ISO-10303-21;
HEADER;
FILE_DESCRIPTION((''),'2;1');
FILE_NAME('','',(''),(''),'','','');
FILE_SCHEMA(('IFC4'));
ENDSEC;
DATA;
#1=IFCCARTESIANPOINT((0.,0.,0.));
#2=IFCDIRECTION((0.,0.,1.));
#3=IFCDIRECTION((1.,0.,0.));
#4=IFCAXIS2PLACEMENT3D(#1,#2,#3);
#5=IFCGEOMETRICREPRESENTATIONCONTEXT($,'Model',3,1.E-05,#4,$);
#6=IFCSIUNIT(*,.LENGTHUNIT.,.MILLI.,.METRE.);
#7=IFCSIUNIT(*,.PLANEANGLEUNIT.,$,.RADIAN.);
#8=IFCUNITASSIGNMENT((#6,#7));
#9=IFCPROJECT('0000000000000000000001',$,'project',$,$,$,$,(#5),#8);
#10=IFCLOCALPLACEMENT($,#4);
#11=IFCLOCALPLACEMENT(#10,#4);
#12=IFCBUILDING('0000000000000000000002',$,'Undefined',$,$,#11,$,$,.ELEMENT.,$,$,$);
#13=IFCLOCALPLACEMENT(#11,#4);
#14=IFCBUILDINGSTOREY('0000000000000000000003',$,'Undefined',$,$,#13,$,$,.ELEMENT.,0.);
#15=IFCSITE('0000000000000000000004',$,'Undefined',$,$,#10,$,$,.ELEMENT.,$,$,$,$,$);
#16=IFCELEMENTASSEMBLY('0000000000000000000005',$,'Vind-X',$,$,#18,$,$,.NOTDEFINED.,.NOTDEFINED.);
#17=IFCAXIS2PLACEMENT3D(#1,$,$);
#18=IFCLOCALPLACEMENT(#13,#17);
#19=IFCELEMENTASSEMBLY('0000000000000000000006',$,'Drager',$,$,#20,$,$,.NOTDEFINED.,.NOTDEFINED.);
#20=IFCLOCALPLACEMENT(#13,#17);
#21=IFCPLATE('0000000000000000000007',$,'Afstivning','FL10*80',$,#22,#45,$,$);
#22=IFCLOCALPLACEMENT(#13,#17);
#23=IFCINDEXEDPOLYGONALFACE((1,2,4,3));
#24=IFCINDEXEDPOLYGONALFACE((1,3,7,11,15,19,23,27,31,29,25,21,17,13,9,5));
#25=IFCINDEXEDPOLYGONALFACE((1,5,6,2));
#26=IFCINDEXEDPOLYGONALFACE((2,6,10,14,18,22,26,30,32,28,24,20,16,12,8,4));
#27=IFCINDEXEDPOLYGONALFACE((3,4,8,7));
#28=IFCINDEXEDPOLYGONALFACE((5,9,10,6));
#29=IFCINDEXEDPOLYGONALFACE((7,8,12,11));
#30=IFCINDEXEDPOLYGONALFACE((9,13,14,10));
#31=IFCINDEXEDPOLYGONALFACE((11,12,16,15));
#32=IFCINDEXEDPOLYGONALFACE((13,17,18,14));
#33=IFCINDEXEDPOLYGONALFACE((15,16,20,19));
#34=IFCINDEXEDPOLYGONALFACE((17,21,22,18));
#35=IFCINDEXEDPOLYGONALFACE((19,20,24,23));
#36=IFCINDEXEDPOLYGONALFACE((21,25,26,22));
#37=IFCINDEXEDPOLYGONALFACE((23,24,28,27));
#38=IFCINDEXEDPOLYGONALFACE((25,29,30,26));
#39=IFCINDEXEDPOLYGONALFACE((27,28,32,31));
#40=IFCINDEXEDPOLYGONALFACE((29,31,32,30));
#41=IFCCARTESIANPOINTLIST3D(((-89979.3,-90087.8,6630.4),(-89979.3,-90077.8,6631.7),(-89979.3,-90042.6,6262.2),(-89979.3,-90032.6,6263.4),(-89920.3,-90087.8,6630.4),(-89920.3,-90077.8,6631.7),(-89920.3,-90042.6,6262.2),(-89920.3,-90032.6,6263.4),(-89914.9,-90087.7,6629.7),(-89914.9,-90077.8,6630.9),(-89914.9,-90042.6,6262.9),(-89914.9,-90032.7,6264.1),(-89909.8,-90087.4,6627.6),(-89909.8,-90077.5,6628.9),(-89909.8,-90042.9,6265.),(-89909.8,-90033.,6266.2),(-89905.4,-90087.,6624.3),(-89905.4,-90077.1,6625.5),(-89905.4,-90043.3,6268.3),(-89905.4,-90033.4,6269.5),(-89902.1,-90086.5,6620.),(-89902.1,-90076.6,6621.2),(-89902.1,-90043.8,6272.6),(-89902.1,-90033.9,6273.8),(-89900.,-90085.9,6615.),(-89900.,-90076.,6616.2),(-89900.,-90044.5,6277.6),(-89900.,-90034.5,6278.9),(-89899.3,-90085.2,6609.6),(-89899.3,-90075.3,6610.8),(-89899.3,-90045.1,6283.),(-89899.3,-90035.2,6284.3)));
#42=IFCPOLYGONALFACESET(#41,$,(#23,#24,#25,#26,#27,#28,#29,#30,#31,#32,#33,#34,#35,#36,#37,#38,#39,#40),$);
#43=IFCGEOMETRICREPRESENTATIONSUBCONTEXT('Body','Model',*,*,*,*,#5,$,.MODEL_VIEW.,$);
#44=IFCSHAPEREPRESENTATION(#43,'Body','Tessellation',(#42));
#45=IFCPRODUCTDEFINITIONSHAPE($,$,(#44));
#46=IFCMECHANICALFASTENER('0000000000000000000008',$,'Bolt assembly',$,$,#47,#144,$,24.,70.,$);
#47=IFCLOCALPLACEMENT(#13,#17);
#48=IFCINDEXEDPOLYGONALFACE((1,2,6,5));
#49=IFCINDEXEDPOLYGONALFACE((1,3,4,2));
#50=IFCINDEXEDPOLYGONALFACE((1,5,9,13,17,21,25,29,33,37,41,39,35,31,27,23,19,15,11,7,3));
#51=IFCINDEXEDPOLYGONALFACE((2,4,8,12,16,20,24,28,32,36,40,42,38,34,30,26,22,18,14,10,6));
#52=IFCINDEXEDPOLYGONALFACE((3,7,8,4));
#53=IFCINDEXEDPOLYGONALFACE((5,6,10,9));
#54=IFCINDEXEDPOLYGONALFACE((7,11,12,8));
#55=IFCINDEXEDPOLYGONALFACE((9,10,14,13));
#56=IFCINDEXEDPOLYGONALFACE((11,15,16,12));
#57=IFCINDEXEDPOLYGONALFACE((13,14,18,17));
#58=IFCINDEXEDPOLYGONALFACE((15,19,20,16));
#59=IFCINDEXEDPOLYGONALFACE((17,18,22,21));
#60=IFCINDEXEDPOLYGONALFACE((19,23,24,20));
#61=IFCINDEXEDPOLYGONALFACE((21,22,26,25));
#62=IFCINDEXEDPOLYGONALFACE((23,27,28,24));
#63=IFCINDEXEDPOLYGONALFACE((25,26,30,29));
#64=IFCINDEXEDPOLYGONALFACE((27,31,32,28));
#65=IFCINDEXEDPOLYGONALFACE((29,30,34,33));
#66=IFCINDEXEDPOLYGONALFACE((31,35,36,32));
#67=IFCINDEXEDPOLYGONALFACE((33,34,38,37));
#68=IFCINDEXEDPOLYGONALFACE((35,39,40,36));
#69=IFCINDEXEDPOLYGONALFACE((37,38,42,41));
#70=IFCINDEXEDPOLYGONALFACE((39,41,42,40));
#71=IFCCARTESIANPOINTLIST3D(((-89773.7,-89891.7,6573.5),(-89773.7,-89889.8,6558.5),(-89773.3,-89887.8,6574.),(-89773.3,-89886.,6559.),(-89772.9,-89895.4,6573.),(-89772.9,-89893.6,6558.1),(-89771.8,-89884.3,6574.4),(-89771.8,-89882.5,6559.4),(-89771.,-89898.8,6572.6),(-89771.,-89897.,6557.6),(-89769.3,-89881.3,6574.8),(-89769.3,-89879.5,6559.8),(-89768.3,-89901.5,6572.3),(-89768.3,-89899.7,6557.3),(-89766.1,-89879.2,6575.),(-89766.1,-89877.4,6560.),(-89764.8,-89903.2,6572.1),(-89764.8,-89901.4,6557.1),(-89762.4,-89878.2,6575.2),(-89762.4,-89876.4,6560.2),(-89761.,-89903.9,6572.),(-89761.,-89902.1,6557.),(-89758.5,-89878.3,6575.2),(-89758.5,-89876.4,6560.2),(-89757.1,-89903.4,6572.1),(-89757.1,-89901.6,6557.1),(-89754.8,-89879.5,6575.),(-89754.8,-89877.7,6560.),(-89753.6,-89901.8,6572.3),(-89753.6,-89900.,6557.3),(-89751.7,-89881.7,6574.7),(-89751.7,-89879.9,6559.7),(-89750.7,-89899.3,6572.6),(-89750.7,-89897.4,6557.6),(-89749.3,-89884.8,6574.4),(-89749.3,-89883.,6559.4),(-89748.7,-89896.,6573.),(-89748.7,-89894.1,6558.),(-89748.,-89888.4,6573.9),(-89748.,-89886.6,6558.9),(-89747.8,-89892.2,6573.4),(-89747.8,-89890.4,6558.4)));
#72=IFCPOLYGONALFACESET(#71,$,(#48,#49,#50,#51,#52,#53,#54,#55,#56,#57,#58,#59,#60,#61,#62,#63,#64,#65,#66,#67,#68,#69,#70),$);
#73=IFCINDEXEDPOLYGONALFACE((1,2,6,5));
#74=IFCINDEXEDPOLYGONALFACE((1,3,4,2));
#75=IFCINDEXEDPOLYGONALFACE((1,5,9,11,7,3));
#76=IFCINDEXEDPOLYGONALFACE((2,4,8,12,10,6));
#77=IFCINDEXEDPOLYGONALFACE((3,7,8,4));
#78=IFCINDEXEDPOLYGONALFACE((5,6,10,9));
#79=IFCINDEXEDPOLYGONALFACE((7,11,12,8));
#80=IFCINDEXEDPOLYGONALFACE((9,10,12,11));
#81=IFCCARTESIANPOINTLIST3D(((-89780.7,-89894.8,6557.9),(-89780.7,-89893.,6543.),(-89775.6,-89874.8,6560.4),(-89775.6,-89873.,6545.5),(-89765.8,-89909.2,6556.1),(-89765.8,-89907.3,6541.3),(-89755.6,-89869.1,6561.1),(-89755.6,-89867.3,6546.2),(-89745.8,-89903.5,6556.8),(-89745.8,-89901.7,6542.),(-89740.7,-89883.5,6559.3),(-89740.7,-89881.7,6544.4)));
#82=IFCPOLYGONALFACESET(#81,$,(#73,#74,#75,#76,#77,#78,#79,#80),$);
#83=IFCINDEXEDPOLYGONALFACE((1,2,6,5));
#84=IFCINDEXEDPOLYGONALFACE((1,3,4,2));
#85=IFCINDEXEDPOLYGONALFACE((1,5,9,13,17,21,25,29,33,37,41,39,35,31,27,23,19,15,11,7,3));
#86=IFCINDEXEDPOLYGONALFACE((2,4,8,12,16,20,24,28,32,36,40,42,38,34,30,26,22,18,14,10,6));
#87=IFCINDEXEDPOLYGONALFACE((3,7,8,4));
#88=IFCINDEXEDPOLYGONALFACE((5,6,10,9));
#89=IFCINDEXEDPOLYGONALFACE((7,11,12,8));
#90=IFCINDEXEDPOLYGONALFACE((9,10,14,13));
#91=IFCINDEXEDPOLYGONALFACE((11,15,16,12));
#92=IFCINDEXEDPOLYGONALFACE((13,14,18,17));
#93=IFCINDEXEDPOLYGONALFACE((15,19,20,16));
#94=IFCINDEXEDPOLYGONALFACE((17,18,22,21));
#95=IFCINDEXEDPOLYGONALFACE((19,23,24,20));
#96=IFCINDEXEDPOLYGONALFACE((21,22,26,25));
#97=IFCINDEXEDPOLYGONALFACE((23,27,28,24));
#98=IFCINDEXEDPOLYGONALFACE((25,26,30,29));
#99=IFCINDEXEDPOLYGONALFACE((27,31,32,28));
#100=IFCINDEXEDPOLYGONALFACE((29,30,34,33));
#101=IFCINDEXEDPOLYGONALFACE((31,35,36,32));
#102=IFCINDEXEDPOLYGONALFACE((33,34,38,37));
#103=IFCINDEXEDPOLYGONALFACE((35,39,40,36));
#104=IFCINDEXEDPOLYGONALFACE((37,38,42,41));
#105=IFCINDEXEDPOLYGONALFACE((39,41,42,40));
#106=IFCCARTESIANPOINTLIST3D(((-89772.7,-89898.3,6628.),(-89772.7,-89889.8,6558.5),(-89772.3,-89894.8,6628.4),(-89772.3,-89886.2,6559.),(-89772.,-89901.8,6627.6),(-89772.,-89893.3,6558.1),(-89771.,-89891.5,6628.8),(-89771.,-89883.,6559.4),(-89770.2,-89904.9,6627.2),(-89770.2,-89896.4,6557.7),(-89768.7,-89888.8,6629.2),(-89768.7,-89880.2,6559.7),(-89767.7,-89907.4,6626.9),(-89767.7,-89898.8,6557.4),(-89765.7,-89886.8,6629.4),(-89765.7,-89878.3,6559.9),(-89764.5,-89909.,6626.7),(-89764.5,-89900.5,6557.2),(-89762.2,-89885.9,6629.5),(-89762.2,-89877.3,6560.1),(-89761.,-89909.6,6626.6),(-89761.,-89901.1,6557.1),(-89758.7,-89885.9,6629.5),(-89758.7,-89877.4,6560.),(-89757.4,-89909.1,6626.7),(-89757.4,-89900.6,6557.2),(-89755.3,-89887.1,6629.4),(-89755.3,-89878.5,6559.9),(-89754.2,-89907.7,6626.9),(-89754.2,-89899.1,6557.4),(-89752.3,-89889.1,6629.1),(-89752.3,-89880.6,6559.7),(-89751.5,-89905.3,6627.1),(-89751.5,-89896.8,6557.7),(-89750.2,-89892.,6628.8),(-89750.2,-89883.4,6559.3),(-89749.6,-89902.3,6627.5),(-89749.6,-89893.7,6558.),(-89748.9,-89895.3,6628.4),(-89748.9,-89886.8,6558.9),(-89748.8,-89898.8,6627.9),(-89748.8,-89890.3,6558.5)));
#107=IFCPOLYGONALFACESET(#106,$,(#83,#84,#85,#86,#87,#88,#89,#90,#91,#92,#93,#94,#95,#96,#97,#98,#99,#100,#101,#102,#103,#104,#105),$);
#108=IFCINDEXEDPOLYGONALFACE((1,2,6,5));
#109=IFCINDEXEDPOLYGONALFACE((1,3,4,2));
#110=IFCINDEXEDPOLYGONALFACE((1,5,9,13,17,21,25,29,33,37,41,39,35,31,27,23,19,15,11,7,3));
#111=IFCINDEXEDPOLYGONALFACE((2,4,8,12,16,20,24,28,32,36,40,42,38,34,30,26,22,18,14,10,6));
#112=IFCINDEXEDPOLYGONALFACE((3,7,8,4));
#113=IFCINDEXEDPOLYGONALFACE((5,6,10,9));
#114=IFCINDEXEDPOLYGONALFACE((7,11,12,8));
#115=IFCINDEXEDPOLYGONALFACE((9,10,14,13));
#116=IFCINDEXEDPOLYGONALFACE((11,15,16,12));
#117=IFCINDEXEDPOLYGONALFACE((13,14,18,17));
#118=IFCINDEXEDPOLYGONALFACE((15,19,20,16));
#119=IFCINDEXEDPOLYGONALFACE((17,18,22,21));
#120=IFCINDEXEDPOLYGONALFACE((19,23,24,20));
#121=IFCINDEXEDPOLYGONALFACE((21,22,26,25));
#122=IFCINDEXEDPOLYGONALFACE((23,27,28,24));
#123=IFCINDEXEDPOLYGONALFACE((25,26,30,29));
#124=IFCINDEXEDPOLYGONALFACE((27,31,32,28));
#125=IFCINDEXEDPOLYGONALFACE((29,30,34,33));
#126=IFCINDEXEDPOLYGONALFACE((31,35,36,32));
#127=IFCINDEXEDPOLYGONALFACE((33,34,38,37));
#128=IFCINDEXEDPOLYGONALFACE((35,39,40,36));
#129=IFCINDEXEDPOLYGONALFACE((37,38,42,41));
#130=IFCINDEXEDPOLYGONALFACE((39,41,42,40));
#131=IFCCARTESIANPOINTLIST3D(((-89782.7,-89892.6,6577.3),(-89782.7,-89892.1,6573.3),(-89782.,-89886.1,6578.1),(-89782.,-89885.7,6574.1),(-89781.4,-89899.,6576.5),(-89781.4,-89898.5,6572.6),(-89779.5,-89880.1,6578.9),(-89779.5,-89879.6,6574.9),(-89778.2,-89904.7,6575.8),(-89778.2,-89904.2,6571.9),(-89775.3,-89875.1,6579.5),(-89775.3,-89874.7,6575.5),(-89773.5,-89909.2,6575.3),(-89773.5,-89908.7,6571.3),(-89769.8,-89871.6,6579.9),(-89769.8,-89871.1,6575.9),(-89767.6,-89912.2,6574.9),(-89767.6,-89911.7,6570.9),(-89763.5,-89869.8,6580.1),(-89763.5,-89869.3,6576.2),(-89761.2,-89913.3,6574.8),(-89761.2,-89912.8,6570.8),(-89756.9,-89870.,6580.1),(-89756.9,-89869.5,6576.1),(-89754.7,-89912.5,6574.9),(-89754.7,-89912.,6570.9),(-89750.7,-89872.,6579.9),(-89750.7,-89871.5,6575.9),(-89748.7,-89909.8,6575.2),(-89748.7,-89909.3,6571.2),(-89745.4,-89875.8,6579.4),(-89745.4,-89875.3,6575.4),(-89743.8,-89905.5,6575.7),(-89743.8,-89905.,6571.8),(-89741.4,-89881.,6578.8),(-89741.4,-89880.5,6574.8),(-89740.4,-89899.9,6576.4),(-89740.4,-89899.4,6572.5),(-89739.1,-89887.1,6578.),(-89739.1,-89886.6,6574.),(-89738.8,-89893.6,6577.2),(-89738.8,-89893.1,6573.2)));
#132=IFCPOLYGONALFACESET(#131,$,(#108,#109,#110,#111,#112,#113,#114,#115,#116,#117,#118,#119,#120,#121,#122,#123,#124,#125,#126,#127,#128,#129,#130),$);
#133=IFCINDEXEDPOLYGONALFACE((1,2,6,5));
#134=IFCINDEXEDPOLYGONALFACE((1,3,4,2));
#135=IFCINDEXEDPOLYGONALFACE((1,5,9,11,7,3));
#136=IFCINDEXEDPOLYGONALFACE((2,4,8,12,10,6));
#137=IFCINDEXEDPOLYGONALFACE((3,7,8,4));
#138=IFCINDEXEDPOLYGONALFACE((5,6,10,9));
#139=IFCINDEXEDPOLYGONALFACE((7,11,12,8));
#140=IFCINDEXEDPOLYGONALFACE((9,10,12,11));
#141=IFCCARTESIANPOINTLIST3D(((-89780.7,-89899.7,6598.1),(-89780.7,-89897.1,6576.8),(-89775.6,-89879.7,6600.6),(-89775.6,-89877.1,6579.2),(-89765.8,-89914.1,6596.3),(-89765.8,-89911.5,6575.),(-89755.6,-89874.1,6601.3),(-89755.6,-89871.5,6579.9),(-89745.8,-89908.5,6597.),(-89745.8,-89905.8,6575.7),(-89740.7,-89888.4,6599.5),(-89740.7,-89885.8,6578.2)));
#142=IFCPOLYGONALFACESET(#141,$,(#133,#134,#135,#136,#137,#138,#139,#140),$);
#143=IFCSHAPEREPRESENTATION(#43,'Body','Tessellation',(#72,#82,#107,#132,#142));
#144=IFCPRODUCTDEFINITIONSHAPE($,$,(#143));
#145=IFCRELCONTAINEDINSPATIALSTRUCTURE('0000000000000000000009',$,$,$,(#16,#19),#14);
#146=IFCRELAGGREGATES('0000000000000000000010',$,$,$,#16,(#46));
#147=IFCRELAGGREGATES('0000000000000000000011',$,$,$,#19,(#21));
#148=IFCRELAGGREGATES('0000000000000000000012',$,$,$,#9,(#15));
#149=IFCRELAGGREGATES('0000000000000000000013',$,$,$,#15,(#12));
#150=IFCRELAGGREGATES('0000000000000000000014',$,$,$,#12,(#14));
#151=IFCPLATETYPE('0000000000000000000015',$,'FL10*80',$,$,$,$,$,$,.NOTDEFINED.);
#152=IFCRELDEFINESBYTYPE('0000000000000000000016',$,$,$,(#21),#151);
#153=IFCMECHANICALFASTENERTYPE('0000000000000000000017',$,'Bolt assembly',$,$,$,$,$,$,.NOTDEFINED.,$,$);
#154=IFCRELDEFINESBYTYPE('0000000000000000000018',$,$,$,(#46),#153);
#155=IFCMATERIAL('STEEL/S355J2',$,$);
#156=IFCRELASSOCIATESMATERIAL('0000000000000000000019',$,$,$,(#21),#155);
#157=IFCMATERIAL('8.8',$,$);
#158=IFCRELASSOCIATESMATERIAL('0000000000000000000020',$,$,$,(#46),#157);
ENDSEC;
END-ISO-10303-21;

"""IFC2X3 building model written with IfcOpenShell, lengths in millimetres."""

from ifc_helpers import new_model, si_unit, frame, frame_2d, origin_with_axes, origin_2d_with_axis, place, context, subcontext, project, spatial, polyline, circle_curve, parameter, trimmed, segment, composite_curve, circle, outline, extrude, source, transform, mapped, material, type_object, element, aggregate, save


model = new_model("IFC2X3")

# Units and contexts
model_context = context("Model", 3, precision=1e-05, world=origin_with_axes())
body_context = subcontext(model_context, "Body", "Model", "MODEL_VIEW")
ifc_project = project(units=[si_unit("LENGTHUNIT", "METRE", prefix="MILLI"), si_unit("PLANEANGLEUNIT", "RADIAN")], contexts=[model_context])

# Site, building, storey
site_placement = place(None, origin_with_axes())
site = spatial("IfcSite", under=ifc_project, at=site_placement, Name="Undefined", CompositionType="ELEMENT")
building_placement = place(site_placement, origin_with_axes())
building = spatial("IfcBuilding", under=site, at=building_placement, Name="Undefined", CompositionType="ELEMENT")
storey_placement = place(building_placement, origin_with_axes())
storey = spatial("IfcBuildingStorey", under=building, at=storey_placement, Name="Undefined", CompositionType="ELEMENT", Elevation=0.0)

# Shared definitions
ifc_material_1 = material(Name="STEEL/S355J2")

# Element assembly
assembly_1_placement = place(storey_placement, origin_with_axes())
assembly_1 = element("IfcElementAssembly", 1, at=assembly_1_placement, inside=storey, Name="Vind-X", AssemblyPlace="NOTDEFINED", PredefinedType="NOTDEFINED")

# Element assembly
assembly_2_placement = place(storey_placement, origin_with_axes())
assembly_2 = element("IfcElementAssembly", 2, at=assembly_2_placement, inside=storey, Name="Drager", AssemblyPlace="NOTDEFINED", PredefinedType="NOTDEFINED")

# Plate
plate_type_1 = type_object("IfcPlateType", Name="FL10*80", PredefinedType="NOTDEFINED")
plate_1_placement = place(assembly_2_placement, frame((-89979.3, -90037.6, 6262.8), z_axis=(0.0, -0.992546, -0.121869), x_axis=(1.0, 0.0, 0.0)))
plate_1 = element("IfcPlate", 3, at=plate_1_placement, type_object=plate_type_1, material=ifc_material_1, Name="Afstivning", Description="FL10*80", context=body_context, shape_type="SweptSolid", body=[
    extrude(outline(composite_curve([segment(polyline([(0.0, 0.0), (59.0, 0.0)]), True, "CONTINUOUS"), segment(trimmed(circle_curve(frame_2d((59.0, 21.0), x_axis=(0.0, -1.0)), 21.0), [parameter(0.0)], [parameter(1.570796)], True, "PARAMETER"), True, "CONTINUOUS"), segment(polyline([(80.0, 21.0), (80.0, 350.0)]), True, "CONTINUOUS"), segment(trimmed(circle_curve(frame_2d((59.0, 350.0), x_axis=(1.0, 0.0)), 21.0), [parameter(0.0)], [parameter(1.570796)], True, "PARAMETER"), True, "CONTINUOUS"), segment(polyline([(59.0, 371.0), (0.0, 371.0), (0.0, 0.0)]), True, "CONTINUOUS")], self_intersect=True)), frame((0.0, 0.0, -5.0), z_axis=(0.0, 0.0, 1.0), x_axis=(1.0, 0.0, 0.0)), (0.0, 0.0, 1.0), 10.0),
])

# Mechanical fastener
ifc_material_2 = material(Name="8.8")
mechanical_fastener_type = type_object("IfcMechanicalFastenerType", Name="Bolt assembly")
shared_shape_1 = source(origin_with_axes(), body_context, "Body", "SweptSolid", [
    extrude(circle(Radius=13.0, at=origin_2d_with_axis()), frame((0.0, 0.0, 0.0), z_axis=(0.0, 1.0, 0.0), x_axis=(1.0, 0.0, 0.0)), (0.0, 0.0, 1.0), 15.1),
    extrude(outline(polyline([(18.0, -10.4), (18.0, 10.4), (0.0, 20.8), (-18.0, 10.4), (-18.0, -10.4), (0.0, -20.8), (18.0, -10.4)])), frame((0.0, -15.0, 0.0), z_axis=(0.0, 1.0, 0.0), x_axis=(1.0, 0.0, 0.0)), (0.0, 0.0, 1.0), 15.0),
    extrude(circle(Radius=12.0, at=origin_2d_with_axis()), frame((0.0, 0.0, 0.0), z_axis=(0.0, 1.0, 0.0), x_axis=(1.0, 0.0, 0.0)), (0.0, 0.0, 1.0), 70.0),
    extrude(circle(Radius=22.0, at=origin_2d_with_axis()), frame((0.0, 15.0, 0.0), z_axis=(0.0, 1.0, 0.0), x_axis=(1.0, 0.0, 0.0)), (0.0, 0.0, 1.0), 4.0),
    extrude(outline(polyline([(18.0, -10.4), (18.0, 10.4), (0.0, 20.8), (-18.0, 10.4), (-18.0, -10.4), (0.0, -20.8), (18.0, -10.4)])), frame((0.0, 19.0, 0.0), z_axis=(0.0, 1.0, 0.0), x_axis=(1.0, 0.0, 0.0)), (0.0, 0.0, 1.0), 21.5),
])
mechanical_fastener_1_placement = place(assembly_1_placement, frame((-89760.7, -89889.2, 6558.6), z_axis=(0.717842, -0.691017, -0.084846), x_axis=(0.696206, 0.712491, 0.087483)))
mechanical_fastener_1 = element("IfcMechanicalFastener", 4, at=mechanical_fastener_1_placement, type_object=mechanical_fastener_type, material=ifc_material_2, Name="Bolt assembly", NominalDiameter=24.0, NominalLength=70.0, context=body_context, shape_type="MappedRepresentation", body=[
    mapped(shared_shape_1, transform((0.0, 0.0, 0.0))),
])
aggregate(assembly_1, [mechanical_fastener_1])
aggregate(assembly_2, [plate_1])

save(model, "model.ifc")
